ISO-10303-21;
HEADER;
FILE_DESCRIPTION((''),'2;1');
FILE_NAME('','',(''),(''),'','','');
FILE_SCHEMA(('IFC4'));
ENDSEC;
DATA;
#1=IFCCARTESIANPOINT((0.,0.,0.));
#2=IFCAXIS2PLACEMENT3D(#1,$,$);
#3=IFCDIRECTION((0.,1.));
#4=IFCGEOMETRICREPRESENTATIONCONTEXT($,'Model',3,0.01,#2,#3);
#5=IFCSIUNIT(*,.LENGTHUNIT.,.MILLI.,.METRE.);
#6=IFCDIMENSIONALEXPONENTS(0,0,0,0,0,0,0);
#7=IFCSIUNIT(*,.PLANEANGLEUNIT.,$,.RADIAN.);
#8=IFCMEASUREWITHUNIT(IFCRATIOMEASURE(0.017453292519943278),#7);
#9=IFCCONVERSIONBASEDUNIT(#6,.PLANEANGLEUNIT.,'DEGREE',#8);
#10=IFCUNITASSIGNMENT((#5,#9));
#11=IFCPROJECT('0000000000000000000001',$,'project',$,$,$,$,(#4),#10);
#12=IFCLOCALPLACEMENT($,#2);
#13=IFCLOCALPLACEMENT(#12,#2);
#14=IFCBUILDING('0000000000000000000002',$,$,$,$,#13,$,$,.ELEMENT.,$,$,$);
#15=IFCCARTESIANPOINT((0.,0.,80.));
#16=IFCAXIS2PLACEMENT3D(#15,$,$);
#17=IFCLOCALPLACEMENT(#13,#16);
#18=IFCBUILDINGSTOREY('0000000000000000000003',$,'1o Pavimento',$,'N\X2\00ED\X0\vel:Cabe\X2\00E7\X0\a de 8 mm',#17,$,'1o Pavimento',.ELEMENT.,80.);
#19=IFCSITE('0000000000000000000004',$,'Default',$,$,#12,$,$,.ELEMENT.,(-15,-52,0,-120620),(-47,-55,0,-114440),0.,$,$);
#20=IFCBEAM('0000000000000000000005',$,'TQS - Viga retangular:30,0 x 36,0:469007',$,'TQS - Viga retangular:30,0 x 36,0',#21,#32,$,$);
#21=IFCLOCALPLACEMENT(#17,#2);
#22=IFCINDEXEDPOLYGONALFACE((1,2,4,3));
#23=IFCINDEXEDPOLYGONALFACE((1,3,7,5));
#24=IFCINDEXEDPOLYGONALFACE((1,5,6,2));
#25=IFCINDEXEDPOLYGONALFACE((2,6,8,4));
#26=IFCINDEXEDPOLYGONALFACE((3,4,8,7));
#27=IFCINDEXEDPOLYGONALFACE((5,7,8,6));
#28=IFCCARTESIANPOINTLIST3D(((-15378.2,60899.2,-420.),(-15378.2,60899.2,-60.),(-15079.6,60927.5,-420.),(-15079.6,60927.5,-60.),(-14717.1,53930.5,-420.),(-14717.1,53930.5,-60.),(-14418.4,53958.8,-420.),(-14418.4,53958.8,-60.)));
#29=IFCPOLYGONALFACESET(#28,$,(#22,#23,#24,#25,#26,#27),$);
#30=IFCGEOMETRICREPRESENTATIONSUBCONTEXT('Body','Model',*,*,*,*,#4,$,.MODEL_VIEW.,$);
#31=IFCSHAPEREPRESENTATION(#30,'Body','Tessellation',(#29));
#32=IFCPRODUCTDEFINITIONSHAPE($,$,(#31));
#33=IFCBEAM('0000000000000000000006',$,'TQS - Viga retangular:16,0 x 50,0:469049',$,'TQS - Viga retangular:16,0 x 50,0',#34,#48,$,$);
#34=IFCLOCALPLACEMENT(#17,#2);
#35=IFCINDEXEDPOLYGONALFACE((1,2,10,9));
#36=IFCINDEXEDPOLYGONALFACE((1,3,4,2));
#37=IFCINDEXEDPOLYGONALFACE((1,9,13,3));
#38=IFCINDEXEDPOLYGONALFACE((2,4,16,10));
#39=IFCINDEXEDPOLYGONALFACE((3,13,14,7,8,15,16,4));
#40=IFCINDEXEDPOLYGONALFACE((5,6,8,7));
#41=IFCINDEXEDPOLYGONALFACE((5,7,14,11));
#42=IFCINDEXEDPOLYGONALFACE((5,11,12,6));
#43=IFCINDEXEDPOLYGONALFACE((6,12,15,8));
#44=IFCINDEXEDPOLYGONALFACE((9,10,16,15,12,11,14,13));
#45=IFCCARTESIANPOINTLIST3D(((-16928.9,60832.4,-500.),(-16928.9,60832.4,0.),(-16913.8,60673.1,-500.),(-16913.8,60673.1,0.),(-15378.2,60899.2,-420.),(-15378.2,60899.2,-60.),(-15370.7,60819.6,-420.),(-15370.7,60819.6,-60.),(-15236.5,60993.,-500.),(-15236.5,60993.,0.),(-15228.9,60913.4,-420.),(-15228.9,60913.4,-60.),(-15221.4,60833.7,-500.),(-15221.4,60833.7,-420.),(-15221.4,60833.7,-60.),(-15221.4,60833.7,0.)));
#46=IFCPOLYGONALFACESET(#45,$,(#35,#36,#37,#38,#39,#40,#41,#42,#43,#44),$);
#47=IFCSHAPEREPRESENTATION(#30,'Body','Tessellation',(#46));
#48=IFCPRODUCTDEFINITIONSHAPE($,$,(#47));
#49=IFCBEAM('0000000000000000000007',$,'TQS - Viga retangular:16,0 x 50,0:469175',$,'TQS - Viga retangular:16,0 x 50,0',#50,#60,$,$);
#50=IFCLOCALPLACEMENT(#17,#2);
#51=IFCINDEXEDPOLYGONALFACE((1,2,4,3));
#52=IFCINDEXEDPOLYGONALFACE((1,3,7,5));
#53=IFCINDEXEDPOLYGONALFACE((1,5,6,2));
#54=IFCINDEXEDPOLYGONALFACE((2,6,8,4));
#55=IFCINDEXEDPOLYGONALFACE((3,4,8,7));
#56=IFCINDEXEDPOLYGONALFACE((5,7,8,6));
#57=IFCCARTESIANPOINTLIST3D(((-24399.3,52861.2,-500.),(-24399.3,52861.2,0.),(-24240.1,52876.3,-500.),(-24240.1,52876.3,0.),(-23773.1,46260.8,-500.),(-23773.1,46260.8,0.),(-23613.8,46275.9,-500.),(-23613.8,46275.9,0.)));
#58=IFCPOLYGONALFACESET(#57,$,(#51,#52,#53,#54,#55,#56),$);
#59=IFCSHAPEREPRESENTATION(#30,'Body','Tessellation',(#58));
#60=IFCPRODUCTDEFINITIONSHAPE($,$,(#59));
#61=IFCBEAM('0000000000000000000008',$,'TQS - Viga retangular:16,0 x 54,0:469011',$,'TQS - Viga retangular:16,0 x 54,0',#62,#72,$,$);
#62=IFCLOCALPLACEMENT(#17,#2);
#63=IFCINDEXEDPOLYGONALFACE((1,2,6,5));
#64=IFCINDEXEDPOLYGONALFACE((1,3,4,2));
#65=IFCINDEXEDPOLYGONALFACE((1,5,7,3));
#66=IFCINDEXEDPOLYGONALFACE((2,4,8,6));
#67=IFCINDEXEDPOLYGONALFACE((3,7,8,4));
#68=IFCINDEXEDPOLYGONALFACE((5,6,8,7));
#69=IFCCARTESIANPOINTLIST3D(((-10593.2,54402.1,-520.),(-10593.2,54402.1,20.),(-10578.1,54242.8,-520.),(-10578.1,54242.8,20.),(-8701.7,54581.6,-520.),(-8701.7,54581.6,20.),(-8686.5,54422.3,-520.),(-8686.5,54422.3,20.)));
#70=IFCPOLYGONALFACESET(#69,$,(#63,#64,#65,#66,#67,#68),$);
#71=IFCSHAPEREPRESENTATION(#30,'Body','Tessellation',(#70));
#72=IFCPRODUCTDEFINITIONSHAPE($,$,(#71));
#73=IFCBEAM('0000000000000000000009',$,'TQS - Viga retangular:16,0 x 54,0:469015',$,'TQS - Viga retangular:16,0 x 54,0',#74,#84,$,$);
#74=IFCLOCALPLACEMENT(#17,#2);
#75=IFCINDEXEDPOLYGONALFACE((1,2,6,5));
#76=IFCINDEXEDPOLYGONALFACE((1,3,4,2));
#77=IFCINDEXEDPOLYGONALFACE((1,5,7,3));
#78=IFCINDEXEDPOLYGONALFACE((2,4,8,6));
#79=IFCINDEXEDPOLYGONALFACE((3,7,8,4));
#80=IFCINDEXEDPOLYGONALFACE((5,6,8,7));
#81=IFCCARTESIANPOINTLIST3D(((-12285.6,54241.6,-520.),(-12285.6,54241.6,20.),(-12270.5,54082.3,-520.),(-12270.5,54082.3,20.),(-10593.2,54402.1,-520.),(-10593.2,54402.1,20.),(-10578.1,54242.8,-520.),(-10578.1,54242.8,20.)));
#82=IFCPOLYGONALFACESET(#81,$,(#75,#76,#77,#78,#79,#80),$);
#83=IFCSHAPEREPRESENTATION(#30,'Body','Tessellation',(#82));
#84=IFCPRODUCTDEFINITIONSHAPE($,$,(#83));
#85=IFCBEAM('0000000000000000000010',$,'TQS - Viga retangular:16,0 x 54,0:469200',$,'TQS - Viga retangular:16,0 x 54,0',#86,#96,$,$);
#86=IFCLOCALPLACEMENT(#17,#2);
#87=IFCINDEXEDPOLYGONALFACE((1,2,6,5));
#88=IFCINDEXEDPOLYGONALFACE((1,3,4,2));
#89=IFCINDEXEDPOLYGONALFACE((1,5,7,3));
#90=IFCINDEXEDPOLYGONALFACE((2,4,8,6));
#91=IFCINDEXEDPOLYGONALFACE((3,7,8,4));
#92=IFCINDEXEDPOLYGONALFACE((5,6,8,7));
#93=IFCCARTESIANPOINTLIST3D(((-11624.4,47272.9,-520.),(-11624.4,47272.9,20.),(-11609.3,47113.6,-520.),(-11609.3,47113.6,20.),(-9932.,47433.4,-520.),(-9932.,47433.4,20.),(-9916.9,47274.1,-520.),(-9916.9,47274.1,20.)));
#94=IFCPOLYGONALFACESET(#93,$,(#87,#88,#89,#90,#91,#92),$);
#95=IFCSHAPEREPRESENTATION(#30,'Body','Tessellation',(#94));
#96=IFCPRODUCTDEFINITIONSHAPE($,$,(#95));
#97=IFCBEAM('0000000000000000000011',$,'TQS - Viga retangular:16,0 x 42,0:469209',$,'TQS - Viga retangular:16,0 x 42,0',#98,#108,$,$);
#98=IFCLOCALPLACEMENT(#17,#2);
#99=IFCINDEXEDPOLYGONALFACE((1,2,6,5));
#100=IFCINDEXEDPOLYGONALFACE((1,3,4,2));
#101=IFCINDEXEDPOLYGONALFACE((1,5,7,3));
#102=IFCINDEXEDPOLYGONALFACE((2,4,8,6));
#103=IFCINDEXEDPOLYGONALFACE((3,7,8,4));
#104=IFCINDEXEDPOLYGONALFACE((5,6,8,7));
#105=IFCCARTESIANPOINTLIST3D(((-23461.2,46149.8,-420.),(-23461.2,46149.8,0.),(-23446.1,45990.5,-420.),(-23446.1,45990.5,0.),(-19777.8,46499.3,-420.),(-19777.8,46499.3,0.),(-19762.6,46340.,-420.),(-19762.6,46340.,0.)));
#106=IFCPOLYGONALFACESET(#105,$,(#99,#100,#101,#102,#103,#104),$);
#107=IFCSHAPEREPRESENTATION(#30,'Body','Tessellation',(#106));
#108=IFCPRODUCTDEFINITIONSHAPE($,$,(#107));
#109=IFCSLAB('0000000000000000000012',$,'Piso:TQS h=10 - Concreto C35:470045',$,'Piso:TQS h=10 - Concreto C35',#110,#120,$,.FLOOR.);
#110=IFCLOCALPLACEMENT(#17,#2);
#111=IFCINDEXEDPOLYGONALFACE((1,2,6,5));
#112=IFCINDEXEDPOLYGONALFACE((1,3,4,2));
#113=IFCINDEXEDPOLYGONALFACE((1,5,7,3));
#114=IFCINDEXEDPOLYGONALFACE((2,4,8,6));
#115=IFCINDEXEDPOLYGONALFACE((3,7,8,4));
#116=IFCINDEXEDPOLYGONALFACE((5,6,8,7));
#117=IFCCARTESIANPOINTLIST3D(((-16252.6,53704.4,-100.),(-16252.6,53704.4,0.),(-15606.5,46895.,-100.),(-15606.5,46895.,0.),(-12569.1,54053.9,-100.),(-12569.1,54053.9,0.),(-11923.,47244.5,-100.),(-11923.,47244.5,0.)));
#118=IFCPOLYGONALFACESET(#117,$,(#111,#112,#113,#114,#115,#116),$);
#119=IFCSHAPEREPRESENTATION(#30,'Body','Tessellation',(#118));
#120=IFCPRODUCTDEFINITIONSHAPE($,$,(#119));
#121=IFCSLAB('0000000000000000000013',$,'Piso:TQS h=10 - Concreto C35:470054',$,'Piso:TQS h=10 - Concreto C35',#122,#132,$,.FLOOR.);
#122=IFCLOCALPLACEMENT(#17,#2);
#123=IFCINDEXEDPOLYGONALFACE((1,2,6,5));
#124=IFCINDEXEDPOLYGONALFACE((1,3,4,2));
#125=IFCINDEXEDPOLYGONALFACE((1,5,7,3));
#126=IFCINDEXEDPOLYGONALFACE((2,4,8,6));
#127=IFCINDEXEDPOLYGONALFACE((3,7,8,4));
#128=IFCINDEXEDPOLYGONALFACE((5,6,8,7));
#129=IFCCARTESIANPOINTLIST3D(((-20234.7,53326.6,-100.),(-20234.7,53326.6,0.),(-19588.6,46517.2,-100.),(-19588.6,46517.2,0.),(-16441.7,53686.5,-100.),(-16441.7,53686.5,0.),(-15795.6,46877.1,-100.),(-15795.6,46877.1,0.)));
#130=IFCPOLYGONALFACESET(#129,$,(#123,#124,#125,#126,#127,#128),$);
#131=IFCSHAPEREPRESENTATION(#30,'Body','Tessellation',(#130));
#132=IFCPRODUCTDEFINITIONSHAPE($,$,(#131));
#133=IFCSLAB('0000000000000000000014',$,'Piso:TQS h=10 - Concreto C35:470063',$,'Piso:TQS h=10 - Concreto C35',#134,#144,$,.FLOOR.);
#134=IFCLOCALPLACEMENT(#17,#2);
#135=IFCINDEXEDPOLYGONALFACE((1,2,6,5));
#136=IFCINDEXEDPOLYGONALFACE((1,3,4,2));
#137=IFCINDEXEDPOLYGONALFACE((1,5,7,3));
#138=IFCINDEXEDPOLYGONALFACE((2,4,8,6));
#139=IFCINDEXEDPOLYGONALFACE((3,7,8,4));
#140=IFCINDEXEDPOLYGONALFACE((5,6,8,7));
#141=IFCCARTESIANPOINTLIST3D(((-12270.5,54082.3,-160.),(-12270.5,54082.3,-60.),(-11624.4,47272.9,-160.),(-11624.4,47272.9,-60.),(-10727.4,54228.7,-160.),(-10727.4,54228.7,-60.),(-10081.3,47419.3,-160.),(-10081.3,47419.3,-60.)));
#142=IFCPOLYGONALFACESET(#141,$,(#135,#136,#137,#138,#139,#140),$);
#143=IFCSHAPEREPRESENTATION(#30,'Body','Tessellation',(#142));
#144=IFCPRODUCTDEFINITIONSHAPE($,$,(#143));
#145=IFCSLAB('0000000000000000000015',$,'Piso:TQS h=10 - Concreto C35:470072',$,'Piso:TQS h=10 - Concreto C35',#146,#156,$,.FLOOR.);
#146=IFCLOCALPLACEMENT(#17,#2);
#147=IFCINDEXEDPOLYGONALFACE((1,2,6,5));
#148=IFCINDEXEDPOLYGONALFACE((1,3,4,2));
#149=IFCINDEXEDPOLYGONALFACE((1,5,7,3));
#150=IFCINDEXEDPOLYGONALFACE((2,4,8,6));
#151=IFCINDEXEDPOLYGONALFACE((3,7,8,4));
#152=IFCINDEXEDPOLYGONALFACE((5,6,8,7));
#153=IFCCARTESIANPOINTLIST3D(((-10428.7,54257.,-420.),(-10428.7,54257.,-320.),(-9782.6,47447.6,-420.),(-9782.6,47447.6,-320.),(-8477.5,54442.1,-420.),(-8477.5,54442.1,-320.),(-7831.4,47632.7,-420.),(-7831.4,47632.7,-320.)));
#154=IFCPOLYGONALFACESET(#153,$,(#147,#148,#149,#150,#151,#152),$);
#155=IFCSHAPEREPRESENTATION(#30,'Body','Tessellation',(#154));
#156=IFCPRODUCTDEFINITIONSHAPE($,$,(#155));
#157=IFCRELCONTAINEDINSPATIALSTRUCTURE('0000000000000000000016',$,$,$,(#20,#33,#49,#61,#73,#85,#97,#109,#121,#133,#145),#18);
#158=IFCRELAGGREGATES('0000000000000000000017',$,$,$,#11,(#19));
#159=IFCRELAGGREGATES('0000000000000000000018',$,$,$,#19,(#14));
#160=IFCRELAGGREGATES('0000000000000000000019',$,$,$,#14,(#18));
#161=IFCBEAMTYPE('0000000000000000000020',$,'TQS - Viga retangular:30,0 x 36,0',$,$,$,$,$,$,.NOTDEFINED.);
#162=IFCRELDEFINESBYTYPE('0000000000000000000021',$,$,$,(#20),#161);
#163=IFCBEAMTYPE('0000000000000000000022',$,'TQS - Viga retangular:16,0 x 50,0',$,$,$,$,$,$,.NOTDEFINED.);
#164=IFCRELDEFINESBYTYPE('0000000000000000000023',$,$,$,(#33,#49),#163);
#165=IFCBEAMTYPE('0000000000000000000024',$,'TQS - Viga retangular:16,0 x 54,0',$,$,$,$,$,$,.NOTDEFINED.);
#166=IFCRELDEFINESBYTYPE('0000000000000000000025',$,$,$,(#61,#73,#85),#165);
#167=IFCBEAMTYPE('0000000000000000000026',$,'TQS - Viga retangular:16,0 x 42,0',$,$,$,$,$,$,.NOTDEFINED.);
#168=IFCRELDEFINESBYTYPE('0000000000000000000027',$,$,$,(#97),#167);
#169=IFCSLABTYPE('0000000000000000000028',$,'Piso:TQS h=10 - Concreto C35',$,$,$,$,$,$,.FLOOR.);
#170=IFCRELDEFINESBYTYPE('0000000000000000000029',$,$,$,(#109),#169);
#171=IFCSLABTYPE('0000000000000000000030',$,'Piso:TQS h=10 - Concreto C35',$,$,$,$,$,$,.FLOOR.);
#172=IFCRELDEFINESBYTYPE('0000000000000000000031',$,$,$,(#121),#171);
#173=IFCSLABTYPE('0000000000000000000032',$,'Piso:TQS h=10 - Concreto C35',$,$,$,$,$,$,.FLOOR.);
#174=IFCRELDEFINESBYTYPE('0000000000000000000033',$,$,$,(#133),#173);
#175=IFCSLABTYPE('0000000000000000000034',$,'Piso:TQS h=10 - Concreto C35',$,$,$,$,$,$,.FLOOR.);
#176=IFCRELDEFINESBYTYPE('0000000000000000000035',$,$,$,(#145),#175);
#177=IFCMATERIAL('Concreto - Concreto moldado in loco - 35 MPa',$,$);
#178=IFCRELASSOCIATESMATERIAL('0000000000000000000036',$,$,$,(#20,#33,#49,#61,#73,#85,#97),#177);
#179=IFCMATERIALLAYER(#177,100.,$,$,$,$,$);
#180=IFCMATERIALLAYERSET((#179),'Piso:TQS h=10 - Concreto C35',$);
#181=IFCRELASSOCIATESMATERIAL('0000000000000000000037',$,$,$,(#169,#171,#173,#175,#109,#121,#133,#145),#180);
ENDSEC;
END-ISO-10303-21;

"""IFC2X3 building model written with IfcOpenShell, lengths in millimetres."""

from ifc_helpers import new_model, entity, si_unit, converted_unit, direction, frame, frame_2d, origin, origin_2d_with_axis, place, context, subcontext, project, spatial, polyline, rectangle, extrude, boolean, clip, bounded_halfspace, material, layer, layer_set, layer_usage, type_object, element, save


model = new_model("IFC2X3")

# Units and contexts
model_context = context("Model", 3, precision=0.01, world=origin(), true_north=direction((0.0, 1.0)))
body_context = subcontext(model_context, "Body", "Model", "MODEL_VIEW")
ifc_project = project(units=[si_unit("LENGTHUNIT", "METRE", prefix="MILLI"), converted_unit("PLANEANGLEUNIT", "DEGREE", entity("IfcRatioMeasure", 0.017453292519943278), si_unit("PLANEANGLEUNIT", "RADIAN"), dimensions=[0, 0, 0, 0, 0, 0, 0])], contexts=[model_context])

# Site, building, storey
site_placement = place(None, origin())
site = spatial("IfcSite", under=ifc_project, at=site_placement, Name="Default", CompositionType="ELEMENT", RefLatitude=(-15, -52, 0, -120620), RefLongitude=(-47, -55, 0, -114440), RefElevation=0.0)
building_placement = place(site_placement, origin())
building = spatial("IfcBuilding", under=site, at=building_placement, CompositionType="ELEMENT")
storey_placement = place(building_placement, frame((0.0, 0.0, 80.0)))
storey = spatial("IfcBuildingStorey", under=building, at=storey_placement, Name="1o Pavimento", ObjectType="Nível:Cabeça de 8 mm", LongName="1o Pavimento", CompositionType="ELEMENT", Elevation=80.0)

# Beams
ifc_material_1 = material(Name="Concreto - Concreto moldado in loco - 35 MPa")
beam_type_1 = type_object("IfcBeamType", Name="TQS - Viga retangular:30,0 x 36,0", PredefinedType="NOTDEFINED")
beam_1_placement = place(storey_placement, frame((-14567.7, 53944.7, -60.0), z_axis=(0.0, 0.0, 1.0), x_axis=(-0.094456, 0.995529, 0.0)))
element("IfcBeam", 1, at=beam_1_placement, inside=storey, type_object=beam_type_1, material=ifc_material_1, Name="TQS - Viga retangular:30,0 x 36,0:469007", ObjectType="TQS - Viga retangular:30,0 x 36,0", context=body_context, shape_type="SweptSolid", body=[
    extrude(rectangle(XDim=360.0, YDim=300.0, at=frame_2d((0.0, 0.0), x_axis=(1.0, 0.0))), frame((0.0, 0.0, -180.0), z_axis=(1.0, 0.0, 0.0), x_axis=(0.0, 0.0, -1.0)), (0.0, 0.0, 1.0), 7000.0),
])
beam_type_2 = type_object("IfcBeamType", Name="TQS - Viga retangular:16,0 x 50,0", PredefinedType="NOTDEFINED")
beam_2_placement = place(storey_placement, frame((-15228.9, 60913.4, 0.0), z_axis=(0.0, 0.0, 1.0), x_axis=(-0.995529, -0.094456, 0.0)))
element("IfcBeam", 2, at=beam_2_placement, inside=storey, type_object=beam_type_2, material=ifc_material_1, Name="TQS - Viga retangular:16,0 x 50,0:469049", ObjectType="TQS - Viga retangular:16,0 x 50,0", context=body_context, shape_type="SweptSolid", body=[
    boolean("DIFFERENCE", clip(extrude(rectangle(XDim=500.0, YDim=160.0, at=frame_2d((0.0, 0.0), x_axis=(1.0, 0.0))), frame((0.0, 0.0, -250.0), z_axis=(1.0, 0.0, 0.0), x_axis=(0.0, 0.0, -1.0)), (0.0, 0.0, 1.0), 1700.0), bounded_halfspace(frame((150.0, 0.0, -420.0), z_axis=(-1.0, 0.0, 0.0), x_axis=(0.0, 1.0, 0.0)), False, frame((0.0, 0.0, -250.0), z_axis=(1.0, 0.0, 0.0), x_axis=(0.0, 0.0, -1.0)), polyline([(170.0, 0.0), (-190.0, 0.0), (-190.0, 80.0), (-90.0, 80.0), (170.0, 80.0), (170.0, 0.0)]))), extrude(rectangle(XDim=360.0, YDim=80.0, at=frame_2d((0.0, 0.0), x_axis=(0.0, 1.0))), frame((0.0, 40.0, -240.0), z_axis=(-1.0, 0.0, 0.0), x_axis=(0.0, -1.0, 0.0)), (0.0, 0.0, -1.0), 150.0)),
])
beam_3_placement = place(storey_placement, frame((-23693.5, 46268.4, 0.0), z_axis=(0.0, 0.0, 1.0), x_axis=(-0.094456, 0.995529, 0.0)))
element("IfcBeam", 3, at=beam_3_placement, inside=storey, type_object=beam_type_2, material=ifc_material_1, Name="TQS - Viga retangular:16,0 x 50,0:469175", ObjectType="TQS - Viga retangular:16,0 x 50,0", context=body_context, shape_type="SweptSolid", body=[
    extrude(rectangle(XDim=500.0, YDim=160.0, at=frame_2d((0.0, 0.0), x_axis=(1.0, 0.0))), frame((0.0, 0.0, -250.0), z_axis=(1.0, 0.0, 0.0), x_axis=(0.0, 0.0, -1.0)), (0.0, 0.0, 1.0), 6630.0),
])
beam_type_3 = type_object("IfcBeamType", Name="TQS - Viga retangular:16,0 x 54,0", PredefinedType="NOTDEFINED")
beam_4_placement = place(storey_placement, frame((-8694.1, 54502.0, 20.0), z_axis=(0.0, 0.0, 1.0), x_axis=(-0.995529, -0.094456, 0.0)))
element("IfcBeam", 4, at=beam_4_placement, inside=storey, type_object=beam_type_3, material=ifc_material_1, Name="TQS - Viga retangular:16,0 x 54,0:469011", ObjectType="TQS - Viga retangular:16,0 x 54,0", context=body_context, shape_type="SweptSolid", body=[
    extrude(rectangle(XDim=540.0, YDim=160.0, at=frame_2d((0.0, 0.0), x_axis=(1.0, 0.0))), frame((0.0, 0.0, -270.0), z_axis=(1.0, 0.0, 0.0), x_axis=(0.0, 0.0, -1.0)), (0.0, 0.0, 1.0), 1900.0),
])
beam_5_placement = place(storey_placement, frame((-10585.6, 54322.5, 20.0), z_axis=(0.0, 0.0, 1.0), x_axis=(-0.995529, -0.094456, 0.0)))
element("IfcBeam", 5, at=beam_5_placement, inside=storey, type_object=beam_type_3, material=ifc_material_1, Name="TQS - Viga retangular:16,0 x 54,0:469015", ObjectType="TQS - Viga retangular:16,0 x 54,0", context=body_context, shape_type="SweptSolid", body=[
    extrude(rectangle(XDim=540.0, YDim=160.0, at=frame_2d((0.0, 0.0), x_axis=(1.0, 0.0))), frame((0.0, 0.0, -270.0), z_axis=(1.0, 0.0, 0.0), x_axis=(0.0, 0.0, -1.0)), (0.0, 0.0, 1.0), 1700.0),
])
beam_6_placement = place(storey_placement, frame((-9924.4, 47353.8, 20.0), z_axis=(0.0, 0.0, 1.0), x_axis=(-0.995529, -0.094456, 0.0)))
element("IfcBeam", 6, at=beam_6_placement, inside=storey, type_object=beam_type_3, material=ifc_material_1, Name="TQS - Viga retangular:16,0 x 54,0:469200", ObjectType="TQS - Viga retangular:16,0 x 54,0", context=body_context, shape_type="SweptSolid", body=[
    extrude(rectangle(XDim=540.0, YDim=160.0, at=frame_2d((0.0, 0.0), x_axis=(1.0, 0.0))), frame((0.0, 0.0, -270.0), z_axis=(1.0, 0.0, 0.0), x_axis=(0.0, 0.0, -1.0)), (0.0, 0.0, 1.0), 1700.0),
])
beam_type_4 = type_object("IfcBeamType", Name="TQS - Viga retangular:16,0 x 42,0", PredefinedType="NOTDEFINED")
beam_7_placement = place(storey_placement, frame((-19675.6, 46428.6, 0.0), z_axis=(0.0, 0.0, 1.0), x_axis=(-0.995529, -0.094456, 0.0)))
element("IfcBeam", 7, at=beam_7_placement, inside=storey, type_object=beam_type_4, material=ifc_material_1, Name="TQS - Viga retangular:16,0 x 42,0:469209", ObjectType="TQS - Viga retangular:16,0 x 42,0", context=body_context, shape_type="SweptSolid", body=[
    extrude(rectangle(XDim=420.0, YDim=160.0, at=frame_2d((0.0, 0.0), x_axis=(1.0, 0.0))), frame((95.0, 0.0, -210.0), z_axis=(1.0, 0.0, 0.0), x_axis=(0.0, 0.0, -1.0)), (0.0, 0.0, 1.0), 3700.0),
])

# Slabs
ifc_layer = layer(ifc_material_1, 100.0)
ifc_layer_set = layer_set([ifc_layer], Name="Piso:TQS h=10 - Concreto C35")
ifc_layer_usage_1 = layer_usage(ifc_layer_set, "AXIS3", "POSITIVE", 0.0)
slab_type_1 = type_object("IfcSlabType", Name="Piso:TQS h=10 - Concreto C35", PredefinedType="FLOOR", material=ifc_layer_set)
slab_1_placement = place(storey_placement, origin())
element("IfcSlab", 8, at=slab_1_placement, inside=storey, type_object=slab_type_1, material=ifc_layer_usage_1, Name="Piso:TQS h=10 - Concreto C35:470045", ObjectType="Piso:TQS h=10 - Concreto C35", PredefinedType="FLOOR", context=body_context, shape_type="SweptSolid", body=[
    extrude(rectangle(XDim=6840.0, YDim=3700.0, at=frame_2d((0.0, 0.0), x_axis=(1.0, 0.0))), frame((-14087.8, 50474.5, 0.0), z_axis=(0.0, 0.0, -1.0), x_axis=(0.094456, -0.995529, 0.0)), (0.0, 0.0, 1.0), 100.0),
])
ifc_layer_usage_2 = layer_usage(ifc_layer_set, "AXIS3", "POSITIVE", 0.0)
slab_type_2 = type_object("IfcSlabType", Name="Piso:TQS h=10 - Concreto C35", PredefinedType="FLOOR", material=ifc_layer_set)
slab_2_placement = place(storey_placement, origin())
element("IfcSlab", 9, at=slab_2_placement, inside=storey, type_object=slab_type_2, material=ifc_layer_usage_2, Name="Piso:TQS h=10 - Concreto C35:470054", ObjectType="Piso:TQS h=10 - Concreto C35", PredefinedType="FLOOR", context=body_context, shape_type="SweptSolid", body=[
    extrude(rectangle(XDim=6840.0, YDim=3810.0, at=frame_2d((0.0, 0.0), x_axis=(1.0, 0.0))), frame((-18015.2, 50101.9, 0.0), z_axis=(0.0, 0.0, -1.0), x_axis=(0.094456, -0.995529, 0.0)), (0.0, 0.0, 1.0), 100.0),
])
ifc_layer_usage_3 = layer_usage(ifc_layer_set, "AXIS3", "POSITIVE", 0.0)
slab_type_3 = type_object("IfcSlabType", Name="Piso:TQS h=10 - Concreto C35", PredefinedType="FLOOR", material=ifc_layer_set)
slab_3_placement = place(storey_placement, origin())
element("IfcSlab", 10, at=slab_3_placement, inside=storey, type_object=slab_type_3, material=ifc_layer_usage_3, Name="Piso:TQS h=10 - Concreto C35:470063", ObjectType="Piso:TQS h=10 - Concreto C35", PredefinedType="FLOOR", context=body_context, shape_type="SweptSolid", body=[
    extrude(rectangle(XDim=1550.0, YDim=6840.0, at=origin_2d_with_axis()), frame((-11175.9, 50750.8, -60.0), z_axis=(0.0, 0.0, -1.0), x_axis=(0.995529, 0.094456, 0.0)), (0.0, 0.0, 1.0), 100.0),
])
ifc_layer_usage_4 = layer_usage(ifc_layer_set, "AXIS3", "POSITIVE", 0.0)
slab_type_4 = type_object("IfcSlabType", Name="Piso:TQS h=10 - Concreto C35", PredefinedType="FLOOR", material=ifc_layer_set)
slab_4_placement = place(storey_placement, origin())
element("IfcSlab", 11, at=slab_4_placement, inside=storey, type_object=slab_type_4, material=ifc_layer_usage_4, Name="Piso:TQS h=10 - Concreto C35:470072", ObjectType="Piso:TQS h=10 - Concreto C35", PredefinedType="FLOOR", context=body_context, shape_type="SweptSolid", body=[
    extrude(rectangle(XDim=6840.0, YDim=1960.0, at=frame_2d((0.0, 0.0), x_axis=(1.0, 0.0))), frame((-9130.1, 50944.9, -320.0), z_axis=(0.0, 0.0, -1.0), x_axis=(0.094456, -0.995529, 0.0)), (0.0, 0.0, 1.0), 100.0),
])

save(model, "model.ifc")
